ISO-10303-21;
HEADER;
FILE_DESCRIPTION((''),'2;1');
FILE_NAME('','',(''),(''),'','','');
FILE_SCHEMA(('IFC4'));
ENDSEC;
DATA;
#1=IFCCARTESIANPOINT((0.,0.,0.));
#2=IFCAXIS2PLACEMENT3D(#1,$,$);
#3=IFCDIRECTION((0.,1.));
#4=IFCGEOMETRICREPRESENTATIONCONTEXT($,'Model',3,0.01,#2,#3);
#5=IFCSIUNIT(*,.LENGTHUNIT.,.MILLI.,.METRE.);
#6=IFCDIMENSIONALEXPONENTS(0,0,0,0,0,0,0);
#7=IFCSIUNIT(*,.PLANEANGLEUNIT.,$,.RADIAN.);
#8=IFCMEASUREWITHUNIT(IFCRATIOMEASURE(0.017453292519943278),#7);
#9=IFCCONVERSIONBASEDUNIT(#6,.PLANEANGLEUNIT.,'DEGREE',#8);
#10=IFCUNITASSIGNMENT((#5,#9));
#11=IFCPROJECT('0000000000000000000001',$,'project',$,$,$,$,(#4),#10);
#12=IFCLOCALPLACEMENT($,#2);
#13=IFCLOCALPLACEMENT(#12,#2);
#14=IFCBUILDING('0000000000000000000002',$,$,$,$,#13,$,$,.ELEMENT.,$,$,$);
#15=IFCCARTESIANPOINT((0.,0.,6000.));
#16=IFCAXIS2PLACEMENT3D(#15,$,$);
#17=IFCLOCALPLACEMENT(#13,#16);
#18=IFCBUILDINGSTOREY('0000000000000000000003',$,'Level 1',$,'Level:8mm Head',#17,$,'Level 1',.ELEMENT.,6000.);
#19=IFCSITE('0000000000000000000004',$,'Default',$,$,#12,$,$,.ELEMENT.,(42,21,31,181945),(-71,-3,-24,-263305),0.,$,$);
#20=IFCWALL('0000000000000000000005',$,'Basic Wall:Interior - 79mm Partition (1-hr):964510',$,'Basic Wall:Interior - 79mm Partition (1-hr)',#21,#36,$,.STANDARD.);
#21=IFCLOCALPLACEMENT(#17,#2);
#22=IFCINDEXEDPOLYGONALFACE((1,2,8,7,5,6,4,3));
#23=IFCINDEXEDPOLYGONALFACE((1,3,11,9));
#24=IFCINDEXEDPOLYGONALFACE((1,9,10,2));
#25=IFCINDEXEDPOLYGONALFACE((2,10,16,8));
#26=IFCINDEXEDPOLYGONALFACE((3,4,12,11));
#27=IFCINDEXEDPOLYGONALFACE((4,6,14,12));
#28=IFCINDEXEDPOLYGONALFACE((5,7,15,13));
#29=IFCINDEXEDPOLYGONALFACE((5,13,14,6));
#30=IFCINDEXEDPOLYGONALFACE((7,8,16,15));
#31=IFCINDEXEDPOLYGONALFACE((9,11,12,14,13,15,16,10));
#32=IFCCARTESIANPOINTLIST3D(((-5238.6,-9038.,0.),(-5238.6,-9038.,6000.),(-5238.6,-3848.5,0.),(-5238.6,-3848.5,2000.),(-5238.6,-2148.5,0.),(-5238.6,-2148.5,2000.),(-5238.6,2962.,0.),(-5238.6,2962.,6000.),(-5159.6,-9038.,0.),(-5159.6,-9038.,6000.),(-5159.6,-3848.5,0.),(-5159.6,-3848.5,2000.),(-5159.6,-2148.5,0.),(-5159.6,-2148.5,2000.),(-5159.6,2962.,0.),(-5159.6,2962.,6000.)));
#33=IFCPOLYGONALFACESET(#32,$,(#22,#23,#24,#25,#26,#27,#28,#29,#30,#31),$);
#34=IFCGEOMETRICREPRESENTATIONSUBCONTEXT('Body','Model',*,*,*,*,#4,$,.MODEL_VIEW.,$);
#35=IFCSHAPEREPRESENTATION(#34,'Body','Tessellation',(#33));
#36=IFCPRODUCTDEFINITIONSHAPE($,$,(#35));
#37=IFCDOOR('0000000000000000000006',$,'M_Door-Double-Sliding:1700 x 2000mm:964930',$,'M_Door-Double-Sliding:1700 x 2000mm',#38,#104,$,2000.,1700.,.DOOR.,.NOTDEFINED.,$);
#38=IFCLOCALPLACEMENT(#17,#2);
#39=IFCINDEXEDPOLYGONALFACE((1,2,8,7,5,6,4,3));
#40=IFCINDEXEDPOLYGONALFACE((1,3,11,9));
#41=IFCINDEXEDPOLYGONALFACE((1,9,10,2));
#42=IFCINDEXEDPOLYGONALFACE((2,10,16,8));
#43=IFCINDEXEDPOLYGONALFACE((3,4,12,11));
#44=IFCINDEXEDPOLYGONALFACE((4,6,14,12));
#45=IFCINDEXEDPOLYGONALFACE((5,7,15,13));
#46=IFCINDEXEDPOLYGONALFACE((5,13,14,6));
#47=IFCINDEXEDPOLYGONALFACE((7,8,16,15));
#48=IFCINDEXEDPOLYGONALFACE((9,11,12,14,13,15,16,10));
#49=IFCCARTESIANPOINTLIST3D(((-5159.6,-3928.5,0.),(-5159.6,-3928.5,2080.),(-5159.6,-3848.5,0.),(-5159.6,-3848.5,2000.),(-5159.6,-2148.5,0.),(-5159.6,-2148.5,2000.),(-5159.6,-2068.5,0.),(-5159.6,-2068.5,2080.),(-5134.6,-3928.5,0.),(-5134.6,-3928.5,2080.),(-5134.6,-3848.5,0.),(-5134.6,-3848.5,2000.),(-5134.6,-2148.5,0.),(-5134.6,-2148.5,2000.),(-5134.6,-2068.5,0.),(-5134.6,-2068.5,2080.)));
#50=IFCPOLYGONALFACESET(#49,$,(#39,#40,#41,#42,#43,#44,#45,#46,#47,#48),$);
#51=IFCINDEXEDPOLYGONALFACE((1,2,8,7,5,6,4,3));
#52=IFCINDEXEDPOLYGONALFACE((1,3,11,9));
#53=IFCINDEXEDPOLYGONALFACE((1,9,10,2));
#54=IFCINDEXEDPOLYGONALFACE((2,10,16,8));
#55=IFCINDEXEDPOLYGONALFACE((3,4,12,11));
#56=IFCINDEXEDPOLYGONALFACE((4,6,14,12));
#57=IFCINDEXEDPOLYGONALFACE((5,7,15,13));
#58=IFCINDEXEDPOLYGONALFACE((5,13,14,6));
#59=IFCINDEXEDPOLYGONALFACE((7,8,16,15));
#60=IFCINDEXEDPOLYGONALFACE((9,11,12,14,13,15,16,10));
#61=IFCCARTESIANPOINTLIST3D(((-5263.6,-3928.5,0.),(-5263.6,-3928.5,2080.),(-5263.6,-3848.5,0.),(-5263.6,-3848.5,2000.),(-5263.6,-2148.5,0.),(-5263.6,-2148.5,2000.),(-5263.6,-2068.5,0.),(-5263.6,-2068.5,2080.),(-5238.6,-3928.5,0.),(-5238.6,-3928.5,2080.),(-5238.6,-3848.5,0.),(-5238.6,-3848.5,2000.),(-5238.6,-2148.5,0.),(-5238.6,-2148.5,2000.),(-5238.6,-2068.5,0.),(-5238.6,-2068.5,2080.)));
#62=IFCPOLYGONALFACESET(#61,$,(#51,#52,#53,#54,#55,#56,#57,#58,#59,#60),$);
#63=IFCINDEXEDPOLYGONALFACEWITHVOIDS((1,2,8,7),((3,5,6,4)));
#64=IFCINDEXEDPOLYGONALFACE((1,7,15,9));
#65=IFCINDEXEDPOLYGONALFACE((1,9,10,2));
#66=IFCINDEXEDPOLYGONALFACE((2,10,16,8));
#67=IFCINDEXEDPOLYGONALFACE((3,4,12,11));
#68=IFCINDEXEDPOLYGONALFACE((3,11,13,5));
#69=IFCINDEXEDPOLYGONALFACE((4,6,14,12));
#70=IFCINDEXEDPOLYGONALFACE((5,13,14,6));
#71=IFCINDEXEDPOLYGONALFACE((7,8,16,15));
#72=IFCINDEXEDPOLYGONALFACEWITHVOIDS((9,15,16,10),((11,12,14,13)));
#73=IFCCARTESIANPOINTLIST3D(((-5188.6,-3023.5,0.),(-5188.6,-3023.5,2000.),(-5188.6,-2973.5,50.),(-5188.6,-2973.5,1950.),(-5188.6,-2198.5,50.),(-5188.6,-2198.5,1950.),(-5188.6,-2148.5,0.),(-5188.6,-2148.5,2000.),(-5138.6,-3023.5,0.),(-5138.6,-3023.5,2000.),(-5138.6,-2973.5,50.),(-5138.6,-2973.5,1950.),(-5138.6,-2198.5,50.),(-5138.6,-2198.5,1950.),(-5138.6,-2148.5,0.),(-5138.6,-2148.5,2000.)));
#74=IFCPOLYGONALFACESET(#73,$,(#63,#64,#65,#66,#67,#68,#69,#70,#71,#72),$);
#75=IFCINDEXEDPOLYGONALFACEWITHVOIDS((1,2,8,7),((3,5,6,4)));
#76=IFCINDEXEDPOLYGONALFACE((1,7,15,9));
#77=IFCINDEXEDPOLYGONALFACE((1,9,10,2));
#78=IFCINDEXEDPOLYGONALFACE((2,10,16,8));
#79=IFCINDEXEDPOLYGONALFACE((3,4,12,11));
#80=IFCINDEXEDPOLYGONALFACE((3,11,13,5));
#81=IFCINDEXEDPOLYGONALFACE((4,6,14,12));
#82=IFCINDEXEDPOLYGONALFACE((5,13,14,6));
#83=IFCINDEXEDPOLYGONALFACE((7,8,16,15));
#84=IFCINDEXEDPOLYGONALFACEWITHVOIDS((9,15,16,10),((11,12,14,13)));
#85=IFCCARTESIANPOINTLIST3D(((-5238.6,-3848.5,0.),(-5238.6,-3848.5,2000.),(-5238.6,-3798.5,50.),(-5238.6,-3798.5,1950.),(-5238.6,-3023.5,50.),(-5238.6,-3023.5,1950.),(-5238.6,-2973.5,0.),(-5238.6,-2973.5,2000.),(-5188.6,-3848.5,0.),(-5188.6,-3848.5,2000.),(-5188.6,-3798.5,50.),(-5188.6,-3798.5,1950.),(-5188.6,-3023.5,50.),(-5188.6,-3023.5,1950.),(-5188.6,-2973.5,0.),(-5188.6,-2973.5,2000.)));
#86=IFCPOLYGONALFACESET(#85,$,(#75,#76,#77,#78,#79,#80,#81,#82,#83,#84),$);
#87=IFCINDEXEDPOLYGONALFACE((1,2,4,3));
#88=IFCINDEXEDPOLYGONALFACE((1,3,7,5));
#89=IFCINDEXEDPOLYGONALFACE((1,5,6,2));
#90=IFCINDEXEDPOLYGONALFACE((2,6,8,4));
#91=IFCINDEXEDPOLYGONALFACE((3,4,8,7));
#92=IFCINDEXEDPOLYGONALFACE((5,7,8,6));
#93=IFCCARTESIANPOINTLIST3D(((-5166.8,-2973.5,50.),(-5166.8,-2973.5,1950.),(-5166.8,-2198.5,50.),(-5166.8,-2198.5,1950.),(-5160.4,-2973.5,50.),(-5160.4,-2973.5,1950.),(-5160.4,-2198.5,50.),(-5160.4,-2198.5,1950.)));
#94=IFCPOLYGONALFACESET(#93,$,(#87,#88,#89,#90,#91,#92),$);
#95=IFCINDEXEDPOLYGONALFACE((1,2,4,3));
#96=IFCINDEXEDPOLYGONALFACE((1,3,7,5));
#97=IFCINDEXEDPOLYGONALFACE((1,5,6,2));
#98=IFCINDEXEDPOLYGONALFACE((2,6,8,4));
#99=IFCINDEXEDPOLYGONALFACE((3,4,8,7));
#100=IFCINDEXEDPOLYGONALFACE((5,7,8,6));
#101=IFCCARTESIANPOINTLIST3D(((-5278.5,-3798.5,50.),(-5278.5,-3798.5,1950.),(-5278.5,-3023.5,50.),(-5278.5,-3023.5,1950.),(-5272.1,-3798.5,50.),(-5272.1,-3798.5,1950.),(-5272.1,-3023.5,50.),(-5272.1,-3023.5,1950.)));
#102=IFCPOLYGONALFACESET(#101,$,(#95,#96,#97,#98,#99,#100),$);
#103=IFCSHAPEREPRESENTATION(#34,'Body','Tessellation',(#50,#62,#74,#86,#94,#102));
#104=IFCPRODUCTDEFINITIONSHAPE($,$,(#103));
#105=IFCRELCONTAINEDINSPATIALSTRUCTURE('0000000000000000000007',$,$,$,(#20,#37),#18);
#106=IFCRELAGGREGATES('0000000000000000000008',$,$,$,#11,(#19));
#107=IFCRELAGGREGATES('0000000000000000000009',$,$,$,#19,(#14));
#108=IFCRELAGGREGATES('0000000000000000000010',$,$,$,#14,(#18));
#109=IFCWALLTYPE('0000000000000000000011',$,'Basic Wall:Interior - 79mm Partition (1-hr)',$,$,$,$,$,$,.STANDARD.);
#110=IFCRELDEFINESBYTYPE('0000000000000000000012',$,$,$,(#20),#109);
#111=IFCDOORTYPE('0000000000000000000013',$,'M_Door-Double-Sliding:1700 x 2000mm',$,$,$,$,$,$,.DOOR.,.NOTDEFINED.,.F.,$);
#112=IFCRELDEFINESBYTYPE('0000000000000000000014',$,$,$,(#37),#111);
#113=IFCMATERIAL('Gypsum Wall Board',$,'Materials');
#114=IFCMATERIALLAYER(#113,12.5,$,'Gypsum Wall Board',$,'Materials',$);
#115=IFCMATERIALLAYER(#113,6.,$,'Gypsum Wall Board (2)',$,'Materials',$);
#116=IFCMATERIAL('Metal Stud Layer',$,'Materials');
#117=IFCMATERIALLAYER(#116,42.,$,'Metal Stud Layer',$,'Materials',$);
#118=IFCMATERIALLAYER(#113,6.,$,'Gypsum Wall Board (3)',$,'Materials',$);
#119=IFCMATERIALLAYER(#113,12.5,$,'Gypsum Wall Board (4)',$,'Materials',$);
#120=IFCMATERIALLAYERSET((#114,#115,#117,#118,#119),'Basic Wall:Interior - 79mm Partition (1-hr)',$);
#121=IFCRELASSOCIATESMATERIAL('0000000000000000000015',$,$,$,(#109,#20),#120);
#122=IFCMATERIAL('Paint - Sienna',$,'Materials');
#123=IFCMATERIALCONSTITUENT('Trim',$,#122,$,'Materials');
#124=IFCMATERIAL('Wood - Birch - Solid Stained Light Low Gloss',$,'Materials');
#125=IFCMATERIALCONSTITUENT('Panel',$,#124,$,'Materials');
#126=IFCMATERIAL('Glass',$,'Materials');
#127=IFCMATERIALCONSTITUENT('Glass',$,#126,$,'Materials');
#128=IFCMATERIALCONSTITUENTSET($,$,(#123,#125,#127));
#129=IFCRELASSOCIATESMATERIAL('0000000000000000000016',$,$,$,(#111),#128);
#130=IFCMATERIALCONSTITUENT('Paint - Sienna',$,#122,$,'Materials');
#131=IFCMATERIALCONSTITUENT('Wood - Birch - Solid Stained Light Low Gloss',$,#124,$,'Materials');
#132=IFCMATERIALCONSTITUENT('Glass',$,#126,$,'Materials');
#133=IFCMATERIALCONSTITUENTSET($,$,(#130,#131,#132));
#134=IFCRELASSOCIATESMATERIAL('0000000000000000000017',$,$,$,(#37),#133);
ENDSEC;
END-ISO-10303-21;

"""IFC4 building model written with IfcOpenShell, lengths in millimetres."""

from ifc_helpers import new_model, entity, si_unit, converted_unit, direction, frame, frame_2d, origin, origin_2d_with_axis, place, context, subcontext, project, spatial, polyline, rectangle, outline, extrude, source, transform, mapped, material, layer, layer_set, layer_usage, constituent, constituent_set, type_object, type_shapes, element, fill, save


model = new_model("IFC4")

# Units and contexts
model_context = context("Model", 3, precision=0.01, world=origin(), true_north=direction((0.0, 1.0)))
body_context = subcontext(model_context, "Body", "Model", "MODEL_VIEW")
ifc_project = project(units=[si_unit("LENGTHUNIT", "METRE", prefix="MILLI"), converted_unit("PLANEANGLEUNIT", "DEGREE", entity("IfcRatioMeasure", 0.017453292519943278), si_unit("PLANEANGLEUNIT", "RADIAN"), dimensions=[0, 0, 0, 0, 0, 0, 0])], contexts=[model_context])

# Site, building, storey
site_placement = place(None, origin())
site = spatial("IfcSite", under=ifc_project, at=site_placement, Name="Default", CompositionType="ELEMENT", RefLatitude=(42, 21, 31, 181945), RefLongitude=(-71, -3, -24, -263305), RefElevation=0.0)
building_placement = place(site_placement, origin())
building = spatial("IfcBuilding", under=site, at=building_placement, CompositionType="ELEMENT")
storey_placement = place(building_placement, frame((0.0, 0.0, 6000.0)))
storey = spatial("IfcBuildingStorey", under=building, at=storey_placement, Name="Level 1", ObjectType="Level:8mm Head", LongName="Level 1", CompositionType="ELEMENT", Elevation=6000.0)

# Shared definitions
ifc_material_1 = material(Name="Gypsum Wall Board", Category="Materials")
ifc_layer_1 = layer(ifc_material_1, 12.5, Name="Gypsum Wall Board", Category="Materials")
ifc_layer_2 = layer(ifc_material_1, 6.0, Name="Gypsum Wall Board (2)", Category="Materials")
ifc_material_2 = material(Name="Metal Stud Layer", Category="Materials")
ifc_layer_3 = layer(ifc_material_2, 42.0, Name="Metal Stud Layer", Category="Materials")
ifc_layer_4 = layer(ifc_material_1, 6.0, Name="Gypsum Wall Board (3)", Category="Materials")
ifc_layer_5 = layer(ifc_material_1, 12.5, Name="Gypsum Wall Board (4)", Category="Materials")
ifc_layer_set_1 = layer_set([ifc_layer_1, ifc_layer_2, ifc_layer_3, ifc_layer_4, ifc_layer_5], Name="Basic Wall:Interior - 79mm Partition (1-hr)")
ifc_layer_usage_1 = layer_usage(ifc_layer_set_1, "AXIS2", "NEGATIVE", 39.5)
wall_type = type_object("IfcWallType", Name="Basic Wall:Interior - 79mm Partition (1-hr)", PredefinedType="STANDARD", material=ifc_layer_set_1)

# Wall, opening, door
ifc_material_3 = material(Name="Paint - Sienna", Category="Materials")
ifc_material_4 = material(Name="Wood - Birch - Solid Stained Light Low Gloss", Category="Materials")
ifc_material_5 = material(Name="Glass", Category="Materials")
ifc_constituent_1 = constituent(ifc_material_3, Name="Trim", Category="Materials")
ifc_constituent_2 = constituent(ifc_material_4, Name="Panel", Category="Materials")
ifc_constituent_3 = constituent(ifc_material_5, Name="Glass", Category="Materials")
ifc_constituent_set_1 = constituent_set(constituents=[ifc_constituent_1, ifc_constituent_2, ifc_constituent_3])
door_type = type_object("IfcDoorType", Name="M_Door-Double-Sliding:1700 x 2000mm", OperationType="NOTDEFINED", ParameterTakesPrecedence=False, PredefinedType="DOOR", material=ifc_constituent_set_1)
shared_shape_1 = source(origin(), body_context, "Body", "SweptSolid", [
    extrude(outline(polyline([(-1020.0, -930.0), (1060.0, -930.0), (1060.0, 930.0), (-1020.0, 930.0), (-1020.0, 850.0), (980.0, 850.0), (980.0, -850.0), (-1020.0, -850.0), (-1020.0, -930.0)])), frame((850.0, -25.0, 1020.0), z_axis=(0.0, 1.0, 0.0), x_axis=(0.0, 0.0, 1.0)), (0.0, 0.0, 1.0), 25.0),
    extrude(outline(polyline([(-930.0, -1020.0), (-850.0, -1020.0), (-850.0, 980.0), (850.0, 980.0), (850.0, -1020.0), (930.0, -1020.0), (930.0, 1060.0), (-930.0, 1060.0), (-930.0, -1020.0)])), frame((850.0, 79.0, 1020.0), z_axis=(0.0, 1.0, 0.0), x_axis=(-1.0, 0.0, 0.0)), (0.0, 0.0, 1.0), 25.0),
    extrude(outline(polyline([(-437.5, -1000.0), (437.5, -1000.0), (437.5, 1000.0), (-437.5, 1000.0), (-437.5, -1000.0)]), holes=[polyline([(-387.5, -950.0), (-387.5, 950.0), (387.5, 950.0), (387.5, -950.0), (-387.5, -950.0)])]), frame((1262.5, -21.0, 1000.0), z_axis=(0.0, 1.0, 0.0), x_axis=(1.0, 0.0, 0.0)), (0.0, 0.0, 1.0), 50.0),
    extrude(outline(polyline([(-1000.0, -437.5), (1000.0, -437.5), (1000.0, 437.5), (-1000.0, 437.5), (-1000.0, -437.5)]), holes=[polyline([(-950.0, -387.5), (-950.0, 387.5), (950.0, 387.5), (950.0, -387.5), (-950.0, -387.5)])]), frame((437.5, 29.0, 1000.0), z_axis=(0.0, 1.0, 0.0), x_axis=(0.0, 0.0, -1.0)), (0.0, 0.0, 1.0), 50.0),
    extrude(rectangle(XDim=6.3, YDim=775.0, at=frame_2d((0.0, 0.0), x_axis=(1.0, 0.0))), frame((1262.5, 4.0, 50.0), z_axis=(0.0, 0.0, 1.0), x_axis=(0.0, -1.0, 0.0)), (0.0, 0.0, 1.0), 1900.0),
    extrude(rectangle(XDim=6.4, YDim=775.0, at=origin_2d_with_axis()), frame((437.5, 115.7, 50.0), z_axis=(0.0, 0.0, 1.0), x_axis=(0.0, 1.0, 0.0)), (0.0, 0.0, 1.0), 1900.0),
])
type_shapes(door_type, [shared_shape_1])
wall_1_placement = place(storey_placement, frame((-5199.1, 2962.0, 0.0), z_axis=(0.0, 0.0, 1.0), x_axis=(0.0, -1.0, 0.0)))
wall_1 = element("IfcWall", 1, at=wall_1_placement, inside=storey, type_object=wall_type, material=ifc_layer_usage_1, Name="Basic Wall:Interior - 79mm Partition (1-hr):964510", ObjectType="Basic Wall:Interior - 79mm Partition (1-hr)", PredefinedType="STANDARD", context=body_context, shape_type="SweptSolid", body=[
    extrude(rectangle(XDim=12000.0, YDim=79.0, at=frame_2d((6000.0, 0.0), x_axis=(1.0, 0.0))), origin(), (0.0, 0.0, 1.0), 6000.0),
])
opening_1_placement = place(wall_1_placement, frame((6810.5, 39.5, 0.0)))
opening_1 = element("IfcOpeningElement", 2, at=opening_1_placement, cuts=wall_1, PredefinedType="OPENING", context=body_context, shape_type="SweptSolid", body=[
    extrude(rectangle(XDim=2000.0, YDim=1700.0, at=frame_2d((1000.0, 850.0), x_axis=(-1.0, 0.0))), frame((0.0, 0.0, 0.0), z_axis=(0.0, -1.0, 0.0), x_axis=(0.0, 0.0, 1.0)), (0.0, 0.0, 1.0), 79.0),
])
ifc_constituent_4 = constituent(ifc_material_3, Name="Paint - Sienna", Category="Materials")
ifc_constituent_5 = constituent(ifc_material_4, Name="Wood - Birch - Solid Stained Light Low Gloss", Category="Materials")
ifc_constituent_6 = constituent(ifc_material_5, Name="Glass", Category="Materials")
ifc_constituent_set_2 = constituent_set(constituents=[ifc_constituent_4, ifc_constituent_5, ifc_constituent_6])
door_1_placement = place(opening_1_placement, frame((0.0, 0.0, 0.0), z_axis=(0.0, 0.0, 1.0), x_axis=(-1.0, 0.0, 0.0)))
door_1 = element("IfcDoor", 3, at=door_1_placement, inside=storey, type_object=door_type, material=ifc_constituent_set_2, Name="M_Door-Double-Sliding:1700 x 2000mm:964930", ObjectType="M_Door-Double-Sliding:1700 x 2000mm", OperationType="NOTDEFINED", OverallHeight=2000.0, OverallWidth=1700.0, PredefinedType="DOOR", context=body_context, shape_type="MappedRepresentation", body=[
    mapped(shared_shape_1, transform((0.0, 0.0, 0.0), scale=1.0)),
])
fill(opening_1, door_1)

save(model, "model.ifc")
